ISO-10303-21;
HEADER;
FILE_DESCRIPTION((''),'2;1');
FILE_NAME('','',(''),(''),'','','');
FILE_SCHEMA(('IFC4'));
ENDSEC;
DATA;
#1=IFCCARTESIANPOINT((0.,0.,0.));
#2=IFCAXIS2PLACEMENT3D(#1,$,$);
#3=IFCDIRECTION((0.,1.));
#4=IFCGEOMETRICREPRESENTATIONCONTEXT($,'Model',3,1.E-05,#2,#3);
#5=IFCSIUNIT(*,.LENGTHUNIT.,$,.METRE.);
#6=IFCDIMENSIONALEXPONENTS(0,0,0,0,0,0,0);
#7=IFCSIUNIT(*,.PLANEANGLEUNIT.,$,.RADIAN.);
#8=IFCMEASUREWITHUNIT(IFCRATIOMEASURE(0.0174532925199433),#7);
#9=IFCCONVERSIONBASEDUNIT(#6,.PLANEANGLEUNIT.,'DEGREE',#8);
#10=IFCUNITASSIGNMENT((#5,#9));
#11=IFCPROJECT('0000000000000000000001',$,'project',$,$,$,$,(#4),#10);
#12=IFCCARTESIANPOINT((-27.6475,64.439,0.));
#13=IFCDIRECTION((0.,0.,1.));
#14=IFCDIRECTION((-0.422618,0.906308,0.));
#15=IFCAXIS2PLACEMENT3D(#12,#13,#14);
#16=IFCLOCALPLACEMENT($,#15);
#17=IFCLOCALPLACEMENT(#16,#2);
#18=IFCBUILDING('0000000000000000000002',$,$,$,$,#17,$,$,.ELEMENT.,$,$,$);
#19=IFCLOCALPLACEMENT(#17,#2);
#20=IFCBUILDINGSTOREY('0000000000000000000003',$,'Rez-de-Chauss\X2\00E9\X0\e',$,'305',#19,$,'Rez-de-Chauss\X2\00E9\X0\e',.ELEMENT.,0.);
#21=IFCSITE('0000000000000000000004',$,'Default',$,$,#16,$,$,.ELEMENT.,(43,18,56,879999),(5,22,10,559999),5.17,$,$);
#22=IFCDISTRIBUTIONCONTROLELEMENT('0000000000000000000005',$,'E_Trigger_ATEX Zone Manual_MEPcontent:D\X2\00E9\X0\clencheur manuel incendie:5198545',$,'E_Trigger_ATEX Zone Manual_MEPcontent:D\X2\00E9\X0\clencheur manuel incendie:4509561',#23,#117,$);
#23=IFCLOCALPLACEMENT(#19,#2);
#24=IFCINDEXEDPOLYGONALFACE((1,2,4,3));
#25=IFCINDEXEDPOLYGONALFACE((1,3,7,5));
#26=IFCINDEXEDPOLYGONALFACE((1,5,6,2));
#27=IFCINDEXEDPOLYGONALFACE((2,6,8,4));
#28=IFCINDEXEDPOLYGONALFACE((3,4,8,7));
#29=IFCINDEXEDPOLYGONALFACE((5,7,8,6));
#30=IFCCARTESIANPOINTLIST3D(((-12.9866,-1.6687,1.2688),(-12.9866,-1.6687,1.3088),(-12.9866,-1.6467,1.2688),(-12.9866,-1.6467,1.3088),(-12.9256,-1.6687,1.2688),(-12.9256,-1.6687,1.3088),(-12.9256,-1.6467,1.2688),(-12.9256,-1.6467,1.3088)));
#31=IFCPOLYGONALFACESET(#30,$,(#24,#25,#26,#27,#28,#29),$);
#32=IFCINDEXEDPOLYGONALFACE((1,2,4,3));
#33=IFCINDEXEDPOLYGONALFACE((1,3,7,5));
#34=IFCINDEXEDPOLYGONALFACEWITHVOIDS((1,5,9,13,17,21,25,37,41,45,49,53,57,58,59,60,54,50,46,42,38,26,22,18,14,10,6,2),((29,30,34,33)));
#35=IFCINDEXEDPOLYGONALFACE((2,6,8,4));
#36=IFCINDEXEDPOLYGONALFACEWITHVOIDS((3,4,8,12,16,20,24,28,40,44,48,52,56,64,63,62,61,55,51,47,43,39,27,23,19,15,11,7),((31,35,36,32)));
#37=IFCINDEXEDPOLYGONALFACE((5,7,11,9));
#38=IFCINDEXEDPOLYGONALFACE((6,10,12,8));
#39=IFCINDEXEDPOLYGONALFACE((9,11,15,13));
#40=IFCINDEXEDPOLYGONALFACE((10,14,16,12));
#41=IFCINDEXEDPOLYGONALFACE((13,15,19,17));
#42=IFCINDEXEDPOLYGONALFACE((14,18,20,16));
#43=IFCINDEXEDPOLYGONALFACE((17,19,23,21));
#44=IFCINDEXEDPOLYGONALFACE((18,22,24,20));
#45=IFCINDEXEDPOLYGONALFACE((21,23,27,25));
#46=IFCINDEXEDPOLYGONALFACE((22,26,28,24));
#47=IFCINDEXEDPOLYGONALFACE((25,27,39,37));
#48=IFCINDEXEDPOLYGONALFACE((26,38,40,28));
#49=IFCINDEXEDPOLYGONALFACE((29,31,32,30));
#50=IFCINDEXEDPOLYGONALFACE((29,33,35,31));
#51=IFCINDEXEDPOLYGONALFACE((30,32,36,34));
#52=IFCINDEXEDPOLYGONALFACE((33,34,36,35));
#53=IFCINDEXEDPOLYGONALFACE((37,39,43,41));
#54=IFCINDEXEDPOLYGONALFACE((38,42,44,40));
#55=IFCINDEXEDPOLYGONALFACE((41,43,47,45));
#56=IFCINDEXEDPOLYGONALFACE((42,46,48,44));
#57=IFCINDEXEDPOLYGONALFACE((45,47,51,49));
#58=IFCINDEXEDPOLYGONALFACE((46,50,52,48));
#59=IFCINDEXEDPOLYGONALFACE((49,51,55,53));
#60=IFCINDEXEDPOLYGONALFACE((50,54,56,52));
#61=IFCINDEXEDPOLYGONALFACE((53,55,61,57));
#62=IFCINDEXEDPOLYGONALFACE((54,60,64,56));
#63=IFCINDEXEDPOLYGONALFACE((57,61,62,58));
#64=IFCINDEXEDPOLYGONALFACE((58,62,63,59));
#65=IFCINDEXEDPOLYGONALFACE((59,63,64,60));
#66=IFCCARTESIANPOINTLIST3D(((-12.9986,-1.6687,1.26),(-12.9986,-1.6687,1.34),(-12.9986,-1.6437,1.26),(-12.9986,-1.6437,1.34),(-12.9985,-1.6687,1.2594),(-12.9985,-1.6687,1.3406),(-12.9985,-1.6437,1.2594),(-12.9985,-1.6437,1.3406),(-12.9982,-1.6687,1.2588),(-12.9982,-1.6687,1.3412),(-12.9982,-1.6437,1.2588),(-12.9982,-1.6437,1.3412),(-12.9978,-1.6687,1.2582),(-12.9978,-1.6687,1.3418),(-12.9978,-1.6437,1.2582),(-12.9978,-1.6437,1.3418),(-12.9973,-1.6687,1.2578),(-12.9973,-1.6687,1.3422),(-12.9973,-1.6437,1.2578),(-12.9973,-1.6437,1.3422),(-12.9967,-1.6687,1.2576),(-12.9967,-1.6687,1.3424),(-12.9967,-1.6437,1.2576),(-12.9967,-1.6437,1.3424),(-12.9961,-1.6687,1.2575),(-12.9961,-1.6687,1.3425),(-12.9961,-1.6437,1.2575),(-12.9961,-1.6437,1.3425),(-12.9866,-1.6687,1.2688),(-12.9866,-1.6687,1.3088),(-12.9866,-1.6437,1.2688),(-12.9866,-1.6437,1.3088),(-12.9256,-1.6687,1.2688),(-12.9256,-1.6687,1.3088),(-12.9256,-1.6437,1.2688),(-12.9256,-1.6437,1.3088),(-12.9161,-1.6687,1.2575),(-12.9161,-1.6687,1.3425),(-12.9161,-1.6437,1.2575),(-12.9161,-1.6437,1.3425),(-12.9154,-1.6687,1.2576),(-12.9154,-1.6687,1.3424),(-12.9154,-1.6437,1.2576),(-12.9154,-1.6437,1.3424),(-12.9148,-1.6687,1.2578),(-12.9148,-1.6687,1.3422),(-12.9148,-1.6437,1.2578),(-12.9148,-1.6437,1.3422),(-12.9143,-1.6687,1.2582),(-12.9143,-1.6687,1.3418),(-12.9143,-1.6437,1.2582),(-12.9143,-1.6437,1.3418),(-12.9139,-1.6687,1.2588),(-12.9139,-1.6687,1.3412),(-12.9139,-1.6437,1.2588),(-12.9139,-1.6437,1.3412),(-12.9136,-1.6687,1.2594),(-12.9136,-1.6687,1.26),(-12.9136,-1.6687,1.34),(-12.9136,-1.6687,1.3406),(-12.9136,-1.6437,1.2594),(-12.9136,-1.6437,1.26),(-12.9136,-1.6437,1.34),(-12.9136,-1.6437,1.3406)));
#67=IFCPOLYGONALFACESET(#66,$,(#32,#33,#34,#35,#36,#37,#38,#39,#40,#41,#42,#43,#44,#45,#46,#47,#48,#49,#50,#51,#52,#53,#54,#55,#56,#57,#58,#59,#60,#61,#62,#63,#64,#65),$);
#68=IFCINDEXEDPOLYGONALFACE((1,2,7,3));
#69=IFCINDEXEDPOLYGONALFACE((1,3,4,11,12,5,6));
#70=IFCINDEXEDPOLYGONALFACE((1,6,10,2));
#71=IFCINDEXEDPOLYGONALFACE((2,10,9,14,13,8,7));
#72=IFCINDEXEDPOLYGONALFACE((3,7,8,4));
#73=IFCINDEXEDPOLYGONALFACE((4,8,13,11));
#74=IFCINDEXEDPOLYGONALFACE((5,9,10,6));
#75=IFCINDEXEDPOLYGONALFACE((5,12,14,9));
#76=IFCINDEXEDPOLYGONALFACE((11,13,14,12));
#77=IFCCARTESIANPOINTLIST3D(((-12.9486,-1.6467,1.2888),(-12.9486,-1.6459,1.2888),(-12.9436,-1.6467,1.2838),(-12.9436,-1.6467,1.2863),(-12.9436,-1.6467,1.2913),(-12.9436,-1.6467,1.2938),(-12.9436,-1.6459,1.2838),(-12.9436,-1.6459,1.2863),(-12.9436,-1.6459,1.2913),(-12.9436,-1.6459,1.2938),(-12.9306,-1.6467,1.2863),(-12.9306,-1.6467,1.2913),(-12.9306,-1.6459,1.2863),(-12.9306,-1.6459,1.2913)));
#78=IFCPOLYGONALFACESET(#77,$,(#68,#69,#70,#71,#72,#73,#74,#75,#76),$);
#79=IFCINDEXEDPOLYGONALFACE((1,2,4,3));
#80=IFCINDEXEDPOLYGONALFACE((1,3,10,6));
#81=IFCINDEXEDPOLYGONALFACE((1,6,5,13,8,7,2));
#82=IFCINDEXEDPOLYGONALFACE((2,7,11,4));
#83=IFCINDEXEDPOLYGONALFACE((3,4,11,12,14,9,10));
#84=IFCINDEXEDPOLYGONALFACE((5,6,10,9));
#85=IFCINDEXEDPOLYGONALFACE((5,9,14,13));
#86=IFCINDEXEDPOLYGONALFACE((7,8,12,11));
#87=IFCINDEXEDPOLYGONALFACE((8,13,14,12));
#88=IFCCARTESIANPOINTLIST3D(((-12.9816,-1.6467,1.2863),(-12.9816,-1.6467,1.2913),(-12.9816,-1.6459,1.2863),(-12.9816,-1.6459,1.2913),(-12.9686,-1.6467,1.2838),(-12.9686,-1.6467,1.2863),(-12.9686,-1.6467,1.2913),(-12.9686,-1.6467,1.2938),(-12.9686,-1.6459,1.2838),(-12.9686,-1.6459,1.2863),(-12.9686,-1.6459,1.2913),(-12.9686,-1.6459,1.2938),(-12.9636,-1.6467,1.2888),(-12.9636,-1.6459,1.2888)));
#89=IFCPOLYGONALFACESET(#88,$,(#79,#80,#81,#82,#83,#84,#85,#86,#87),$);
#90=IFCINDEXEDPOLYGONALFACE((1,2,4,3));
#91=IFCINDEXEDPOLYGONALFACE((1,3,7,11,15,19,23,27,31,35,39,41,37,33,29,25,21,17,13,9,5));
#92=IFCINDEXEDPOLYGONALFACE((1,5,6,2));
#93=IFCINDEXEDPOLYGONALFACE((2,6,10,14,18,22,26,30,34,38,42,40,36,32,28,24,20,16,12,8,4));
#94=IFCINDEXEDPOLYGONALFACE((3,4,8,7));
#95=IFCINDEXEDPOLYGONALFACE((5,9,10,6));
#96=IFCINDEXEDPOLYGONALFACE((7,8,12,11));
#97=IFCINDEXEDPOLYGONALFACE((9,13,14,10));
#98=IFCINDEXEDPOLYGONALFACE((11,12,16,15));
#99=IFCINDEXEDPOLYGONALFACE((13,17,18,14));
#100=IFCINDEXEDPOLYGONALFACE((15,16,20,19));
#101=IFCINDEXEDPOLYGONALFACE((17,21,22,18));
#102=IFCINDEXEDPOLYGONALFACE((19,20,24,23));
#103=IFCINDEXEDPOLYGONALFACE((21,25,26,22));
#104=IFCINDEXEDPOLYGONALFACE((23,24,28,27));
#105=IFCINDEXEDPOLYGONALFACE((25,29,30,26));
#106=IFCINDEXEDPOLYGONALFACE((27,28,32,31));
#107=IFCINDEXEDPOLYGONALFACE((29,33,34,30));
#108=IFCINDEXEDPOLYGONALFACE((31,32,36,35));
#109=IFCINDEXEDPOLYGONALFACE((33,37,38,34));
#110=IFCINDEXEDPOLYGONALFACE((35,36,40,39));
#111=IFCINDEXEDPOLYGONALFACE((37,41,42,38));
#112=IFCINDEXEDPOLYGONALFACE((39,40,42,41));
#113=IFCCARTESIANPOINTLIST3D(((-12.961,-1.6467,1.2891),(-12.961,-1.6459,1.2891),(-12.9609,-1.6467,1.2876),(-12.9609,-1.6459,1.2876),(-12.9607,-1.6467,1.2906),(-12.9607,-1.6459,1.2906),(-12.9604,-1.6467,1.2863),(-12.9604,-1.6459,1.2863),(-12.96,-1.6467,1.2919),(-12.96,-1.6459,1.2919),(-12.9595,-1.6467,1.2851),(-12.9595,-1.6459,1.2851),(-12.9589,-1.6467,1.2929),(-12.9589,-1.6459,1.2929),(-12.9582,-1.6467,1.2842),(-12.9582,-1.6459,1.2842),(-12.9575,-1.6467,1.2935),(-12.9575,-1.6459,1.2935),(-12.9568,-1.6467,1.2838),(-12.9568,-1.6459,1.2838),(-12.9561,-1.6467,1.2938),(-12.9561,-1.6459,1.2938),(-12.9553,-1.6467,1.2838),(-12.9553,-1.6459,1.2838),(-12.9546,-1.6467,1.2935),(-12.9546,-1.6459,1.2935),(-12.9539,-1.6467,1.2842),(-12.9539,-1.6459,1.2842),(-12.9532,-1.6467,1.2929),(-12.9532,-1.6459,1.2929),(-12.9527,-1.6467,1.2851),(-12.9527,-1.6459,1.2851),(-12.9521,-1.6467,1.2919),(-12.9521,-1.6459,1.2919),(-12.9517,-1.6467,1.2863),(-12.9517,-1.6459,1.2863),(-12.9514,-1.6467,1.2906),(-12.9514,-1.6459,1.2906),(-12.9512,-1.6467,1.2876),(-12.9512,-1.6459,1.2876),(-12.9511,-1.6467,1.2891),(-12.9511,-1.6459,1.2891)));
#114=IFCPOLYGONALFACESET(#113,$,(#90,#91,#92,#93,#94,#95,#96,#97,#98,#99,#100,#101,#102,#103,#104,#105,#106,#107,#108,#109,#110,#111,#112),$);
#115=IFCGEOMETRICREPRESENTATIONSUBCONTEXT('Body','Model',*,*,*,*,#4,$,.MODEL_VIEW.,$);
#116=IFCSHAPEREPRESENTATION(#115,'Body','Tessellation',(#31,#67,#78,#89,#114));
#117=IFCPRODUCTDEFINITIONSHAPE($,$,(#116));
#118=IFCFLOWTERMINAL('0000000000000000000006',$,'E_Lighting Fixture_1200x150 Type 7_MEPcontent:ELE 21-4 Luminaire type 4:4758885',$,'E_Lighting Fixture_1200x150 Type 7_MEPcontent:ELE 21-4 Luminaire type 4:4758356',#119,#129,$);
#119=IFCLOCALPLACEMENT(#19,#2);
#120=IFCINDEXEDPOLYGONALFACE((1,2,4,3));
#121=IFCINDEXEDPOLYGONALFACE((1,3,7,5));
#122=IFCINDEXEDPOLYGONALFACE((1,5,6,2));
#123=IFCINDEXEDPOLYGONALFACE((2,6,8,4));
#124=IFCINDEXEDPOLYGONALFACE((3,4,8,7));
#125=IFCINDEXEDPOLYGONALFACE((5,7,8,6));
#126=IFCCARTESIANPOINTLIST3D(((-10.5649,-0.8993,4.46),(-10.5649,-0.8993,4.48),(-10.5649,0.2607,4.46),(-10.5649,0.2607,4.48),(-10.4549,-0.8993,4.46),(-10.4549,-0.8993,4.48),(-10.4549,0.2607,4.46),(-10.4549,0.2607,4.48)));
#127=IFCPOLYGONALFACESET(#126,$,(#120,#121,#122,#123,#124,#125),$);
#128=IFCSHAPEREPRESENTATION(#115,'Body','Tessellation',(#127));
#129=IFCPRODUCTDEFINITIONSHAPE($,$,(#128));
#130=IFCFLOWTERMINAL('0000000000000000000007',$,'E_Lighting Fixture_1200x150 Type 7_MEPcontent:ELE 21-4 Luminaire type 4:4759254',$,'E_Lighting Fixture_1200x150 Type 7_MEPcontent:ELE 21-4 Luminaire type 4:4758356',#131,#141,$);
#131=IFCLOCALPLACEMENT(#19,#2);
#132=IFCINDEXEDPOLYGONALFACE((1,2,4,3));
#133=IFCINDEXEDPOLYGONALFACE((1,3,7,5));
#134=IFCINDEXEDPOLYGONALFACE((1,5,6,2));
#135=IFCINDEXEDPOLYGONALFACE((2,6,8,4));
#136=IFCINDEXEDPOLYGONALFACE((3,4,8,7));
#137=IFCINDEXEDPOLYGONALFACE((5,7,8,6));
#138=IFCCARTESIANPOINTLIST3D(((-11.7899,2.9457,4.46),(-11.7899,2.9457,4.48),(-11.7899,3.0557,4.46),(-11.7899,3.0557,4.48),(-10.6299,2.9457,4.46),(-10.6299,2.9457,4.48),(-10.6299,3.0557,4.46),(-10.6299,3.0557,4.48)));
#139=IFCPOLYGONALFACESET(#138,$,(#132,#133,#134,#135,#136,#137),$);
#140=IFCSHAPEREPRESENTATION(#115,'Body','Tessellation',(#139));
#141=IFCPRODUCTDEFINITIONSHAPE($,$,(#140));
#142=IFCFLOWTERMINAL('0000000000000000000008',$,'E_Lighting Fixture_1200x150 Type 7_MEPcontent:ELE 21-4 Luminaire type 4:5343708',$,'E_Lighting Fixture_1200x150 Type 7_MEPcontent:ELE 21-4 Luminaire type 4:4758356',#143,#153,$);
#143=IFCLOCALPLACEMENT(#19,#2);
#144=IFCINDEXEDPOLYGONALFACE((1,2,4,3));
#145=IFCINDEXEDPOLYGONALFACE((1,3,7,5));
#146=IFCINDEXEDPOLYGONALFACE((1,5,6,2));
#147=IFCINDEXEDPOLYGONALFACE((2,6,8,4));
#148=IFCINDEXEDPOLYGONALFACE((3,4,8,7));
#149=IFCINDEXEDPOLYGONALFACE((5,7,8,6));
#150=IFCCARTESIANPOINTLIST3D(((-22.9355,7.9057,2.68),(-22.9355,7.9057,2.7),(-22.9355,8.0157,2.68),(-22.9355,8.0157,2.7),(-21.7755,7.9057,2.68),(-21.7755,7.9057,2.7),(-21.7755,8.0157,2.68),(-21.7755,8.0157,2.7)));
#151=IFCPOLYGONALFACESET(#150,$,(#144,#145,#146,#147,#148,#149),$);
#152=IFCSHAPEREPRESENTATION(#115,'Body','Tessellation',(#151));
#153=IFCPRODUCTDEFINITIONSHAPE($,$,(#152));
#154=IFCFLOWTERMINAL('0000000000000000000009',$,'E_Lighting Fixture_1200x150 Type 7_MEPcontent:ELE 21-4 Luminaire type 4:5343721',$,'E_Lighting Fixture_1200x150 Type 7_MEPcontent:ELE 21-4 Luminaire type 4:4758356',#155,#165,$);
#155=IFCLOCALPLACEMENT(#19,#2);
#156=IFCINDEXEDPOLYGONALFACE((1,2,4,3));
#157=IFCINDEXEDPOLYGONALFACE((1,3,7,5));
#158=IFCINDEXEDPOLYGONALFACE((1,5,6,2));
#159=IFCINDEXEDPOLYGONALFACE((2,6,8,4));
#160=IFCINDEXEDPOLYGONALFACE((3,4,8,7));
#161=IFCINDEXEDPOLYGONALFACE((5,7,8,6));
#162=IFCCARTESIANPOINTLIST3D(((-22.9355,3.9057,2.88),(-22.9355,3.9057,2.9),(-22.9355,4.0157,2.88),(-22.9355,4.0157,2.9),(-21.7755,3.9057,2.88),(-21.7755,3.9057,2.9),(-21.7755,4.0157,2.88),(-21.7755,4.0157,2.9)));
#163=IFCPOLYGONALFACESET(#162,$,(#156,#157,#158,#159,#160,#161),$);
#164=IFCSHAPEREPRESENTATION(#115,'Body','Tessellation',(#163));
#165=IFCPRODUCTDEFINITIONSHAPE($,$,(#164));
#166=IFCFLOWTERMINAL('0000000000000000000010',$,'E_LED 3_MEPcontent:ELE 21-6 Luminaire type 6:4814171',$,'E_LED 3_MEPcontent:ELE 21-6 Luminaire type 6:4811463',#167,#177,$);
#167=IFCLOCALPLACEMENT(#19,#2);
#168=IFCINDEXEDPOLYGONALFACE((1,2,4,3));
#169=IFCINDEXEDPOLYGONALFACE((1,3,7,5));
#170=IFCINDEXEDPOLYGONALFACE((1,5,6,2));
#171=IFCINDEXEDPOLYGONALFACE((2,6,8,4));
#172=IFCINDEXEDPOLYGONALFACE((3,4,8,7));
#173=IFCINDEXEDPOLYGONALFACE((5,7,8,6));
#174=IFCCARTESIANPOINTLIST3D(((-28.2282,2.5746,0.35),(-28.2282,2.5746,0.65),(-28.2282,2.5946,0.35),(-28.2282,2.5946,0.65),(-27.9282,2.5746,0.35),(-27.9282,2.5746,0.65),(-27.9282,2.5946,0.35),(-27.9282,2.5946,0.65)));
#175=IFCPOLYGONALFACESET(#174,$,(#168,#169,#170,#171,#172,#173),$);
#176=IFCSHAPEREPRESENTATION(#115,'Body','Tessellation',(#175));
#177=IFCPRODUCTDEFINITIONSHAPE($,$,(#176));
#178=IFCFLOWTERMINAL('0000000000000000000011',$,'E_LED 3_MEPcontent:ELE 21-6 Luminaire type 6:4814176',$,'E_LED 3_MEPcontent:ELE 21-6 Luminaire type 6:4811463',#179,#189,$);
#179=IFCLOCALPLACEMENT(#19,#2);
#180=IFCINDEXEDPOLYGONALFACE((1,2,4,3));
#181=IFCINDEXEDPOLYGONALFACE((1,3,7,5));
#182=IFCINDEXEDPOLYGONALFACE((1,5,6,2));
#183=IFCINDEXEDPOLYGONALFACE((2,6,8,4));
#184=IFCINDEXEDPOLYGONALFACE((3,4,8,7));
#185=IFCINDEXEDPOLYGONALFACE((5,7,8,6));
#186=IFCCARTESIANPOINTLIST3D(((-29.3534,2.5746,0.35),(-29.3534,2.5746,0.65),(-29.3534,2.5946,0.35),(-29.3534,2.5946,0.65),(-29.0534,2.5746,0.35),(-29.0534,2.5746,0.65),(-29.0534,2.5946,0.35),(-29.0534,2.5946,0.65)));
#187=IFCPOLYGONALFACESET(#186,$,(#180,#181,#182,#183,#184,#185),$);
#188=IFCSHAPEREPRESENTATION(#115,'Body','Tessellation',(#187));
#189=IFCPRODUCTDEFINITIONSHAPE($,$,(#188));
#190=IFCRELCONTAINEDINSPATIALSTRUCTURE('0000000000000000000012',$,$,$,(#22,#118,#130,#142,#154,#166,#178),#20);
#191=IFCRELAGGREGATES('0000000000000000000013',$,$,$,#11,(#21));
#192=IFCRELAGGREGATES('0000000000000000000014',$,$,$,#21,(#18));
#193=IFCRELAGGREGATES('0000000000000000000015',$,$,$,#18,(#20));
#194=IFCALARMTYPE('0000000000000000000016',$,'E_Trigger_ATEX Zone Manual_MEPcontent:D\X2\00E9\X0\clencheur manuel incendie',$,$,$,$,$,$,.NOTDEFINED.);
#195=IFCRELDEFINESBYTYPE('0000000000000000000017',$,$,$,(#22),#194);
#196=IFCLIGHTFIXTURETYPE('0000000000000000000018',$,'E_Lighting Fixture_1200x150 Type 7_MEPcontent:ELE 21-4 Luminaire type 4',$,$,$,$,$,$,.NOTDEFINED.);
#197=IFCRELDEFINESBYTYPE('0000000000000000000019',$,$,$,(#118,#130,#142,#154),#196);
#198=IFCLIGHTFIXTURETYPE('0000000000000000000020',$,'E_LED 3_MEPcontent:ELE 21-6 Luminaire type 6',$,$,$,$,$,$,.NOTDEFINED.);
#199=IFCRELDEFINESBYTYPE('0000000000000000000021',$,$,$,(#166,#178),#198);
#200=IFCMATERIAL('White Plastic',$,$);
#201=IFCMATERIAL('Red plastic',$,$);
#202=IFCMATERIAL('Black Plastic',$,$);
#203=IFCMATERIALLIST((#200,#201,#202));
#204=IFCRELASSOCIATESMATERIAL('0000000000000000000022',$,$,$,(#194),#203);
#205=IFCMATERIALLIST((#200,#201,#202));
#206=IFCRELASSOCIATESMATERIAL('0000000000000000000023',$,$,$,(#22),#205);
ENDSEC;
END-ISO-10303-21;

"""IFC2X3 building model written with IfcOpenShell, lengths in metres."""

from ifc_helpers import new_model, entity, si_unit, converted_unit, direction, frame, frame_2d, origin, origin_2d_with_axis, place, context, subcontext, project, spatial, polyline, circle_curve, parameter, trimmed, segment, composite_curve, rectangle, circle, outline, extrude, source, transform, mapped, material, material_list, type_object, type_shapes, element, save


model = new_model("IFC2X3")

# Units and contexts
model_context = context("Model", 3, precision=1e-05, world=origin(), true_north=direction((0.0, 1.0)))
body_context = subcontext(model_context, "Body", "Model", "MODEL_VIEW")
ifc_project = project(units=[si_unit("LENGTHUNIT", "METRE"), converted_unit("PLANEANGLEUNIT", "DEGREE", entity("IfcRatioMeasure", 0.0174532925199433), si_unit("PLANEANGLEUNIT", "RADIAN"), dimensions=[0, 0, 0, 0, 0, 0, 0])], contexts=[model_context])

# Site, building, storey
site_placement = place(None, frame((-27.6475, 64.439, 0.0), z_axis=(0.0, 0.0, 1.0), x_axis=(-0.422618, 0.906308, 0.0)))
site = spatial("IfcSite", under=ifc_project, at=site_placement, Name="Default", CompositionType="ELEMENT", RefLatitude=(43, 18, 56, 879999), RefLongitude=(5, 22, 10, 559999), RefElevation=5.17)
building_placement = place(site_placement, origin())
building = spatial("IfcBuilding", under=site, at=building_placement, CompositionType="ELEMENT")
storey_placement = place(building_placement, origin())
storey = spatial("IfcBuildingStorey", under=building, at=storey_placement, Name="Rez-de-Chaussée", ObjectType="305", LongName="Rez-de-Chaussée", CompositionType="ELEMENT", Elevation=0.0)

# Distribution control element
ifc_material_1 = material(Name="White Plastic")
ifc_material_2 = material(Name="Red plastic")
ifc_material_3 = material(Name="Black Plastic")
ifc_material_list_1 = material_list([ifc_material_1, ifc_material_2, ifc_material_3])
ifc_material_list_2 = material_list([ifc_material_1, ifc_material_2, ifc_material_3])
alarm_type_1 = type_object("IfcAlarmType", Name="E_Trigger_ATEX Zone Manual_MEPcontent:Déclencheur manuel incendie", PredefinedType="NOTDEFINED", material=ifc_material_list_2)
shared_shape_1 = source(origin(), body_context, "Body", "SweptSolid", [
    extrude(rectangle(XDim=0.022, YDim=0.061, at=frame_2d((0.0, 0.0), x_axis=(1.0, 0.0))), frame((0.0, 0.011, -0.0312), z_axis=(0.0, 0.0, 1.0), x_axis=(0.0, -1.0, 0.0)), (0.0, 0.0, 1.0), 0.04),
    extrude(outline(composite_curve([segment(polyline([(-0.04, -0.0425), (0.04, -0.0425)]), True, "CONTINUOUS"), segment(trimmed(circle_curve(frame_2d((0.04, -0.04), x_axis=(-1.0, 0.0)), 0.0025), [parameter(90.0)], [parameter(180.0)], True, "PARAMETER"), True, "CONTINUOUS"), segment(polyline([(0.0425, -0.04), (0.0425, 0.04)]), True, "CONTINUOUS"), segment(trimmed(circle_curve(frame_2d((0.04, 0.04), x_axis=(-1.0, 0.0)), 0.0025), [parameter(180.0)], [parameter(270.0)], True, "PARAMETER"), True, "CONTINUOUS"), segment(polyline([(0.04, 0.0425), (-0.04, 0.0425)]), True, "CONTINUOUS"), segment(trimmed(circle_curve(frame_2d((-0.04, 0.04), x_axis=(-1.0, 0.0)), 0.0025), [parameter(270.0)], [parameter(0.0)], True, "PARAMETER"), True, "CONTINUOUS"), segment(polyline([(-0.0425, 0.04), (-0.0425, -0.04)]), True, "CONTINUOUS"), segment(trimmed(circle_curve(frame_2d((-0.04, -0.04), x_axis=(-1.0, 0.0)), 0.0025), [parameter(360.0)], [parameter(90.0)], True, "PARAMETER"), True, "CONTINUOUS")], self_intersect=False), holes=[polyline([(-0.0305, -0.0088), (-0.0305, 0.0312), (0.0305, 0.0312), (0.0305, -0.0088), (-0.0305, -0.0088)])]), frame((0.0, 0.0, 0.0), z_axis=(0.0, 1.0, 0.0), x_axis=(1.0, 0.0, 0.0)), (0.0, 0.0, 1.0), 0.025),
    extrude(outline(polyline([(-0.01, 0.0025), (-0.01, -0.0025), (0.003, -0.0025), (0.003, -0.005), (0.008, 0.0), (0.003, 0.005), (0.003, 0.0025), (-0.01, 0.0025)])), frame((0.0155, 0.022, -0.0112), z_axis=(0.0, -1.0, 0.0), x_axis=(-1.0, 0.0, 0.0)), (0.0, 0.0, -1.0), 0.0008),
    extrude(outline(polyline([(-0.0014, -0.0057), (0.0057, -0.0057), (0.0057, 0.0014), (0.0039, -0.0004), (-0.0053, 0.0088), (-0.0088, 0.0053), (0.0004, -0.0039), (-0.0014, -0.0057)])), frame((-0.0155, 0.022, -0.0112), z_axis=(0.0, 1.0, 0.0), x_axis=(0.707107, 0.0, -0.707107)), (0.0, 0.0, 1.0), 0.0008),
    extrude(circle(Radius=0.005, at=frame_2d((0.0, 0.0), x_axis=(1.0, 0.0))), frame((0.0, 0.022, -0.0112), z_axis=(0.0, 1.0, 0.0), x_axis=(0.0, 0.0, 1.0)), (0.0, 0.0, 1.0), 0.0008),
])
type_shapes(alarm_type_1, [shared_shape_1])
distribution_control_element_1_placement = place(storey_placement, frame((-12.9561, -1.6687, 1.3)))
element("IfcDistributionControlElement", 1, at=distribution_control_element_1_placement, inside=storey, type_object=alarm_type_1, material=ifc_material_list_1, Name="E_Trigger_ATEX Zone Manual_MEPcontent:Déclencheur manuel incendie:5198545", ObjectType="E_Trigger_ATEX Zone Manual_MEPcontent:Déclencheur manuel incendie:4509561", context=body_context, shape_type="MappedRepresentation", body=[
    mapped(shared_shape_1, transform((0.0, 0.0, 0.0), scale=1.0)),
])

# Flow terminals
light_fixture_type_1 = type_object("IfcLightFixtureType", Name="E_Lighting Fixture_1200x150 Type 7_MEPcontent:ELE 21-4 Luminaire type 4", PredefinedType="NOTDEFINED")
shared_shape_2 = source(origin(), body_context, "Body", "SweptSolid", [
    extrude(rectangle(XDim=0.11, YDim=1.16, at=origin_2d_with_axis()), frame((0.0, 0.0, 0.0), z_axis=(0.0, 0.0, 1.0), x_axis=(0.0, -1.0, 0.0)), (0.0, 0.0, 1.0), 0.02),
])
type_shapes(light_fixture_type_1, [shared_shape_2])
flow_terminal_1_placement = place(storey_placement, frame((-10.5099, -0.3193, 4.46), z_axis=(0.0, 0.0, 1.0), x_axis=(0.0, -1.0, 0.0)))
element("IfcFlowTerminal", 2, at=flow_terminal_1_placement, inside=storey, type_object=light_fixture_type_1, Name="E_Lighting Fixture_1200x150 Type 7_MEPcontent:ELE 21-4 Luminaire type 4:4758885", ObjectType="E_Lighting Fixture_1200x150 Type 7_MEPcontent:ELE 21-4 Luminaire type 4:4758356", context=body_context, shape_type="MappedRepresentation", body=[
    mapped(shared_shape_2, transform((0.0, 0.0, 0.0), scale=1.0)),
])
for number, where, name in (
    (3, (-11.2099, 3.0007, 4.46), "E_Lighting Fixture_1200x150 Type 7_MEPcontent:ELE 21-4 Luminaire type 4:4759254"),
    (4, (-22.3555, 7.9607, 2.68), "E_Lighting Fixture_1200x150 Type 7_MEPcontent:ELE 21-4 Luminaire type 4:5343708"),
    (5, (-22.3555, 3.9607, 2.88), "E_Lighting Fixture_1200x150 Type 7_MEPcontent:ELE 21-4 Luminaire type 4:5343721"),
):
    element("IfcFlowTerminal", number, at=place(storey_placement, frame(where)), inside=storey, type_object=light_fixture_type_1, Name=name, ObjectType="E_Lighting Fixture_1200x150 Type 7_MEPcontent:ELE 21-4 Luminaire type 4:4758356", context=body_context, shape_type="MappedRepresentation", body=[
        mapped(shared_shape_2, transform((0.0, 0.0, 0.0), scale=1.0)),
    ])
light_fixture_type_2 = type_object("IfcLightFixtureType", Name="E_LED 3_MEPcontent:ELE 21-6 Luminaire type 6", PredefinedType="NOTDEFINED")
shared_shape_3 = source(origin(), body_context, "Body", "SweptSolid", [
    extrude(rectangle(XDim=0.02, YDim=0.3, at=origin_2d_with_axis()), frame((-0.01, 0.0, -0.15)), (0.0, 0.0, 1.0), 0.3),
])
type_shapes(light_fixture_type_2, [shared_shape_3])
for number, where, z_axis, x_axis, name in (
    (6, (-28.0782, 2.5746, 0.5), (0.0, 0.0, 1.0), (0.0, -1.0, 0.0), "E_LED 3_MEPcontent:ELE 21-6 Luminaire type 6:4814171"),
    (7, (-29.2034, 2.5746, 0.5), (0.0, 0.0, 1.0), (0.0, -1.0, 0.0), "E_LED 3_MEPcontent:ELE 21-6 Luminaire type 6:4814176"),
):
    element("IfcFlowTerminal", number, at=place(storey_placement, frame(where, z_axis=z_axis, x_axis=x_axis)), inside=storey, type_object=light_fixture_type_2, Name=name, ObjectType="E_LED 3_MEPcontent:ELE 21-6 Luminaire type 6:4811463", context=body_context, shape_type="MappedRepresentation", body=[
        mapped(shared_shape_3, transform((0.0, 0.0, 0.0), scale=1.0)),
    ])

save(model, "model.ifc")
